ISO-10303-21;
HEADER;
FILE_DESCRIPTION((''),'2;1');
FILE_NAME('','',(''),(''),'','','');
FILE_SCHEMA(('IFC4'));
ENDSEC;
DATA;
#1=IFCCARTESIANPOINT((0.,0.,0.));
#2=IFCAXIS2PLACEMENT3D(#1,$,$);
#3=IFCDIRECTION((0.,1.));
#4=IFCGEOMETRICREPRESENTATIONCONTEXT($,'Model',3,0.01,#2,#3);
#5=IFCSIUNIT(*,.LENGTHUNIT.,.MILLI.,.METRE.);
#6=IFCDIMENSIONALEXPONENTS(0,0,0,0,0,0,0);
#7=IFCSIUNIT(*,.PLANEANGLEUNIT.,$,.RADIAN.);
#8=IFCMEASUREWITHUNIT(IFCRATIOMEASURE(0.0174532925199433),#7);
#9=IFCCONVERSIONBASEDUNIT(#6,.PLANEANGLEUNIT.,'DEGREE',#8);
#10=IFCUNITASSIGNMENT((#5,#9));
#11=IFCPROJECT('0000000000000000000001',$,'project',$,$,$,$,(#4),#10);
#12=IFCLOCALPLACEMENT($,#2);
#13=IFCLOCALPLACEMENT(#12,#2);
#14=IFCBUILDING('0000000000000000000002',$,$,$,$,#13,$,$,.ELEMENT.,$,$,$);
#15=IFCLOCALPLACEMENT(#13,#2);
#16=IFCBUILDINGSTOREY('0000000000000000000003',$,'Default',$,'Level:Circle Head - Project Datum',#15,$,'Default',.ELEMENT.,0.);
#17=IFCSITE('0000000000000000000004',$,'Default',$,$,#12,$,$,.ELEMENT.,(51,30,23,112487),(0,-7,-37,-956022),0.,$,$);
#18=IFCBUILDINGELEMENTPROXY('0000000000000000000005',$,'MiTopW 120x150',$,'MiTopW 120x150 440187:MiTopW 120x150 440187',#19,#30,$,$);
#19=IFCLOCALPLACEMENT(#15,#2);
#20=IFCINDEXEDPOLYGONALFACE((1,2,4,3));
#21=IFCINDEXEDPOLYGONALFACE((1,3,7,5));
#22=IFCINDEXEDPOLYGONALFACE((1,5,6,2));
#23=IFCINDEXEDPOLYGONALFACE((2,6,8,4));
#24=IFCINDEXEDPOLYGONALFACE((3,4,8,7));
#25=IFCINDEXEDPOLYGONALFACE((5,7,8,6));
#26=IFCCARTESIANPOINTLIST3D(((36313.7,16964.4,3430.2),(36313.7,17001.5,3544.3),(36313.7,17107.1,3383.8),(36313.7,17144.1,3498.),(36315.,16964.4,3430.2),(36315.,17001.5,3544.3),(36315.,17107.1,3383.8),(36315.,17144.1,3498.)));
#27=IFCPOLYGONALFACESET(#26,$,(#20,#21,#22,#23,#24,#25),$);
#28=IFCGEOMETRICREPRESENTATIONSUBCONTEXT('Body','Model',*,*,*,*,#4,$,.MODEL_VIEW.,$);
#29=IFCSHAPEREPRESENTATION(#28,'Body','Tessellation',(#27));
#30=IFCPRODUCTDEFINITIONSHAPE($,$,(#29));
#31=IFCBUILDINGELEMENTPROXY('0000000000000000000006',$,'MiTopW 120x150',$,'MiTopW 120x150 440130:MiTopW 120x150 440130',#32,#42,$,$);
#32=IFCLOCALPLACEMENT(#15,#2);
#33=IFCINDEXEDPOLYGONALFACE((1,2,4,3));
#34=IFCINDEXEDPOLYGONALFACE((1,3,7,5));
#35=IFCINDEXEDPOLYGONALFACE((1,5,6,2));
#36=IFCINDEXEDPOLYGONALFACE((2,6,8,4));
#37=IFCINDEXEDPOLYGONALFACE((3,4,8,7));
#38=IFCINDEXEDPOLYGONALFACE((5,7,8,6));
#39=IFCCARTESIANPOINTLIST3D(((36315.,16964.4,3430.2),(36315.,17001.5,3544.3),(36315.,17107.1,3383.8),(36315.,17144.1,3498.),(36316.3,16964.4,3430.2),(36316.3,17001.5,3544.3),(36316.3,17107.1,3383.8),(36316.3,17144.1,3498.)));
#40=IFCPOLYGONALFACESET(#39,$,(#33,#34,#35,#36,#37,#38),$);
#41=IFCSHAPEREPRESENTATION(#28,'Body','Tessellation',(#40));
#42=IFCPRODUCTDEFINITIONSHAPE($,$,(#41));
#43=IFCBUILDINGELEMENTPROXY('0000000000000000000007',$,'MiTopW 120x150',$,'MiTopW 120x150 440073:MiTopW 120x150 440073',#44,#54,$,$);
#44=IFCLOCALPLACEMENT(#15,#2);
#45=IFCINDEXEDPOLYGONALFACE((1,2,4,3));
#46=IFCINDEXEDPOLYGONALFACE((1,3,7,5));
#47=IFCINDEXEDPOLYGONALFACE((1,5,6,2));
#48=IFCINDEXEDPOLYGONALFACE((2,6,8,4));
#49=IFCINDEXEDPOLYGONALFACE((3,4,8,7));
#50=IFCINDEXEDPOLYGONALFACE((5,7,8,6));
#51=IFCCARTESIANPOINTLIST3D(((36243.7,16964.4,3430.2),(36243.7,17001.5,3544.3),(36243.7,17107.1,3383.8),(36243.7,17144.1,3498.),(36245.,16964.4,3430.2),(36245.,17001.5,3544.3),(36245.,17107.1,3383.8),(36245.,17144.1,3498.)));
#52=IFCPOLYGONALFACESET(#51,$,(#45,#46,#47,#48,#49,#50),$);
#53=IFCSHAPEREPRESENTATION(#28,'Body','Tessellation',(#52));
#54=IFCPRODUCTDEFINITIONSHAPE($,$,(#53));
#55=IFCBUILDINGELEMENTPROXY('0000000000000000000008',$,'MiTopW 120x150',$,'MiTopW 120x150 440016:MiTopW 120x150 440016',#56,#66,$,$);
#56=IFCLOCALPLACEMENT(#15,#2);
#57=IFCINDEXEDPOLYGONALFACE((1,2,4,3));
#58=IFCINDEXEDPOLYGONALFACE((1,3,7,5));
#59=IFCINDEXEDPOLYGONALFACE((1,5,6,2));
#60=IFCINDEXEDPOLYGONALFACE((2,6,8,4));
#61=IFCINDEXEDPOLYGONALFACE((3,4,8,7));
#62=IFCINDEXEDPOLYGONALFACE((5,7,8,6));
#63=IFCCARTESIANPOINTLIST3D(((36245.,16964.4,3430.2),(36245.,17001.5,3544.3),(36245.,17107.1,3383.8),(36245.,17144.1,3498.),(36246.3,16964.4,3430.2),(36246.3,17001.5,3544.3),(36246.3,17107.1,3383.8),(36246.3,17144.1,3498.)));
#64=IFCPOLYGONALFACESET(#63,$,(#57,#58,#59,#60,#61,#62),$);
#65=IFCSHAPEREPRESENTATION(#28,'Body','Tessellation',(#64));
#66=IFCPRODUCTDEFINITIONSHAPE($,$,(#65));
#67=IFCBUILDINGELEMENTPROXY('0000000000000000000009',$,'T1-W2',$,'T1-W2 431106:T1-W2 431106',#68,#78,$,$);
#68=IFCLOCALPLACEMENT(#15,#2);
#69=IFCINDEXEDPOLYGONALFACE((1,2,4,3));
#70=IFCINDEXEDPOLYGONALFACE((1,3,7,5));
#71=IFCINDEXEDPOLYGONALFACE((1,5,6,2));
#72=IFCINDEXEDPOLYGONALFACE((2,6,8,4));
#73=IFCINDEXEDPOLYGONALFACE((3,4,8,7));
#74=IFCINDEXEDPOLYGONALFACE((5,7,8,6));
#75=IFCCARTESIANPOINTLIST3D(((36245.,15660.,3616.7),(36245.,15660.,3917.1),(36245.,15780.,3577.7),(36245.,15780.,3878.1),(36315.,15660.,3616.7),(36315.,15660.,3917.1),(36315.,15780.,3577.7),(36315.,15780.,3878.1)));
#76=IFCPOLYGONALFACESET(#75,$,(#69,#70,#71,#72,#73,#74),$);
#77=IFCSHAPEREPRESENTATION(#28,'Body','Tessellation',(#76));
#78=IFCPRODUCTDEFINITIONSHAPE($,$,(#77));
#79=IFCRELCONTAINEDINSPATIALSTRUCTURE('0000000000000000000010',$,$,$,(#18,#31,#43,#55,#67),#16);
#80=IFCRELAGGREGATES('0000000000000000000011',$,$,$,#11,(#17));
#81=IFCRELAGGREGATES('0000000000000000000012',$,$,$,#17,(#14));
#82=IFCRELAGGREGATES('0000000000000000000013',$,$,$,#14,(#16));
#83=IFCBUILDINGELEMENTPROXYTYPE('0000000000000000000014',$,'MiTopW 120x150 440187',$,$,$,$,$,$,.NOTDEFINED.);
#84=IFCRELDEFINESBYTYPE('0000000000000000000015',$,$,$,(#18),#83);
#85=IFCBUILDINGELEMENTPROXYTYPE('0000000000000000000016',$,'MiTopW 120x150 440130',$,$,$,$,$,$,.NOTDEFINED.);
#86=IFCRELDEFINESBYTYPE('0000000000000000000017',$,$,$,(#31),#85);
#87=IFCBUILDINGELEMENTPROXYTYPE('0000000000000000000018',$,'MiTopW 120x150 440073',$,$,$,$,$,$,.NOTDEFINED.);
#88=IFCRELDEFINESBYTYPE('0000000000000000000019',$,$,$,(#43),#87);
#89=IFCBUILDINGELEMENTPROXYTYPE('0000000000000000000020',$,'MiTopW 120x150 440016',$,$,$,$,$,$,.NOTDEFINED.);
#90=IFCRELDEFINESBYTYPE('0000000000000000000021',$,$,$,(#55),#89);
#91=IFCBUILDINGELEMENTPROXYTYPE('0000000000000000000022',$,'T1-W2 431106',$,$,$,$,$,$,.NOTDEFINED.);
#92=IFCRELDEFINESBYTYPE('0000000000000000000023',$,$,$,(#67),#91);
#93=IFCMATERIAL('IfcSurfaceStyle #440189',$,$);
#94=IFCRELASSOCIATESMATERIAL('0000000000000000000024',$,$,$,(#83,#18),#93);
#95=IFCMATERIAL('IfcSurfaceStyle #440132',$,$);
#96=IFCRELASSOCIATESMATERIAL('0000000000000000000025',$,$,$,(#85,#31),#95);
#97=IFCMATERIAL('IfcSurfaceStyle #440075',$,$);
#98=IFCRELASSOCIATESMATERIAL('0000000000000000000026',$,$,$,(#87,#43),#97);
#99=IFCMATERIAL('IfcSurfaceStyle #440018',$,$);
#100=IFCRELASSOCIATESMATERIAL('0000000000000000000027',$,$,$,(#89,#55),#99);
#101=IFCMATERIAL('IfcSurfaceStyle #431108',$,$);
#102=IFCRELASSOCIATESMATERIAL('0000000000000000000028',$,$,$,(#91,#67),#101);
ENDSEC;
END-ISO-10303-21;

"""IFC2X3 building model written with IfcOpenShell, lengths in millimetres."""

from ifc_helpers import new_model, entity, si_unit, converted_unit, direction, frame, origin, place, context, subcontext, project, spatial, polyline, outline, extrude, source, transform, mapped, material, type_object, type_shapes, element, save


model = new_model("IFC2X3")

# Units and contexts
model_context = context("Model", 3, precision=0.01, world=origin(), true_north=direction((0.0, 1.0)))
body_context = subcontext(model_context, "Body", "Model", "MODEL_VIEW")
ifc_project = project(units=[si_unit("LENGTHUNIT", "METRE", prefix="MILLI"), converted_unit("PLANEANGLEUNIT", "DEGREE", entity("IfcRatioMeasure", 0.0174532925199433), si_unit("PLANEANGLEUNIT", "RADIAN"), dimensions=[0, 0, 0, 0, 0, 0, 0])], contexts=[model_context])

# Site, building, storey
site_placement = place(None, origin())
site = spatial("IfcSite", under=ifc_project, at=site_placement, Name="Default", CompositionType="ELEMENT", RefLatitude=(51, 30, 23, 112487), RefLongitude=(0, -7, -37, -956022), RefElevation=0.0)
building_placement = place(site_placement, origin())
building = spatial("IfcBuilding", under=site, at=building_placement, CompositionType="ELEMENT")
storey_placement = place(building_placement, origin())
storey = spatial("IfcBuildingStorey", under=building, at=storey_placement, Name="Default", ObjectType="Level:Circle Head - Project Datum", LongName="Default", CompositionType="ELEMENT", Elevation=0.0)

# Building element proxies
ifc_material_1 = material(Name="IfcSurfaceStyle #440189")
building_element_proxy_type_1 = type_object("IfcBuildingElementProxyType", Name="MiTopW 120x150 440187", PredefinedType="NOTDEFINED", material=ifc_material_1)
shared_shape_1 = source(origin(), body_context, "Body", "SweptSolid", [
    extrude(outline(polyline([(-75.0, -60.0), (75.0, -60.0), (75.0, 60.0), (-75.0, 60.0), (-75.0, -60.0)])), frame((75.0, 60.0, 0.0), z_axis=(0.0, 0.0, 1.0), x_axis=(-1.0, 0.0, 0.0)), (0.0, 0.0, 1.0), 1.3),
])
type_shapes(building_element_proxy_type_1, [shared_shape_1])
proxy_1_placement = place(building_placement, frame((36315.0, 17107.1, 3383.8), z_axis=(-1.0, 0.0, 0.0), x_axis=(0.0, -0.951057, 0.309017)))
element("IfcBuildingElementProxy", 1, at=proxy_1_placement, inside=storey, type_object=building_element_proxy_type_1, material=ifc_material_1, Name="MiTopW 120x150", ObjectType="MiTopW 120x150 440187:MiTopW 120x150 440187", context=body_context, shape_type="MappedRepresentation", body=[
    mapped(shared_shape_1, transform((0.0, 0.0, 0.0), scale=1.0)),
])
ifc_material_2 = material(Name="IfcSurfaceStyle #440132")
building_element_proxy_type_2 = type_object("IfcBuildingElementProxyType", Name="MiTopW 120x150 440130", PredefinedType="NOTDEFINED", material=ifc_material_2)
shared_shape_2 = source(origin(), body_context, "Body", "SweptSolid", [
    extrude(outline(polyline([(-75.0, -60.0), (75.0, -60.0), (75.0, 60.0), (-75.0, 60.0), (-75.0, -60.0)])), frame((75.0, 60.0, 0.0), z_axis=(0.0, 0.0, 1.0), x_axis=(-1.0, 0.0, 0.0)), (0.0, 0.0, 1.0), 1.3),
])
type_shapes(building_element_proxy_type_2, [shared_shape_2])
proxy_2_placement = place(building_placement, frame((36316.3, 17107.1, 3383.8), z_axis=(-1.0, 0.0, 0.0), x_axis=(0.0, -0.951057, 0.309017)))
element("IfcBuildingElementProxy", 2, at=proxy_2_placement, inside=storey, type_object=building_element_proxy_type_2, material=ifc_material_2, Name="MiTopW 120x150", ObjectType="MiTopW 120x150 440130:MiTopW 120x150 440130", context=body_context, shape_type="MappedRepresentation", body=[
    mapped(shared_shape_2, transform((0.0, 0.0, 0.0), scale=1.0)),
])
ifc_material_3 = material(Name="IfcSurfaceStyle #440075")
building_element_proxy_type_3 = type_object("IfcBuildingElementProxyType", Name="MiTopW 120x150 440073", PredefinedType="NOTDEFINED", material=ifc_material_3)
shared_shape_3 = source(origin(), body_context, "Body", "SweptSolid", [
    extrude(outline(polyline([(-75.0, -60.0), (75.0, -60.0), (75.0, 60.0), (-75.0, 60.0), (-75.0, -60.0)])), frame((75.0, 60.0, 0.0), z_axis=(0.0, 0.0, 1.0), x_axis=(-1.0, 0.0, 0.0)), (0.0, 0.0, 1.0), 1.3),
])
type_shapes(building_element_proxy_type_3, [shared_shape_3])
proxy_3_placement = place(building_placement, frame((36245.0, 17107.1, 3383.8), z_axis=(-1.0, 0.0, 0.0), x_axis=(0.0, -0.951057, 0.309017)))
element("IfcBuildingElementProxy", 3, at=proxy_3_placement, inside=storey, type_object=building_element_proxy_type_3, material=ifc_material_3, Name="MiTopW 120x150", ObjectType="MiTopW 120x150 440073:MiTopW 120x150 440073", context=body_context, shape_type="MappedRepresentation", body=[
    mapped(shared_shape_3, transform((0.0, 0.0, 0.0), scale=1.0)),
])
ifc_material_4 = material(Name="IfcSurfaceStyle #440018")
building_element_proxy_type_4 = type_object("IfcBuildingElementProxyType", Name="MiTopW 120x150 440016", PredefinedType="NOTDEFINED", material=ifc_material_4)
shared_shape_4 = source(origin(), body_context, "Body", "SweptSolid", [
    extrude(outline(polyline([(-75.0, -60.0), (75.0, -60.0), (75.0, 60.0), (-75.0, 60.0), (-75.0, -60.0)])), frame((75.0, 60.0, 0.0), z_axis=(0.0, 0.0, 1.0), x_axis=(-1.0, 0.0, 0.0)), (0.0, 0.0, 1.0), 1.3),
])
type_shapes(building_element_proxy_type_4, [shared_shape_4])
proxy_4_placement = place(building_placement, frame((36246.3, 17107.1, 3383.8), z_axis=(-1.0, 0.0, 0.0), x_axis=(0.0, -0.951057, 0.309017)))
element("IfcBuildingElementProxy", 4, at=proxy_4_placement, inside=storey, type_object=building_element_proxy_type_4, material=ifc_material_4, Name="MiTopW 120x150", ObjectType="MiTopW 120x150 440016:MiTopW 120x150 440016", context=body_context, shape_type="MappedRepresentation", body=[
    mapped(shared_shape_4, transform((0.0, 0.0, 0.0), scale=1.0)),
])
ifc_material_5 = material(Name="IfcSurfaceStyle #431108")
building_element_proxy_type_5 = type_object("IfcBuildingElementProxyType", Name="T1-W2 431106", PredefinedType="NOTDEFINED", material=ifc_material_5)
shared_shape_5 = source(origin(), body_context, "Body", "SweptSolid", [
    extrude(outline(polyline([(-130.7, -60.0), (169.7, -60.0), (130.7, 60.0), (-169.7, 60.0), (-130.7, -60.0)])), frame((169.7, 60.0, 0.0), z_axis=(0.0, 0.0, 1.0), x_axis=(-1.0, 0.0, 0.0)), (0.0, 0.0, 1.0), 70.0),
])
type_shapes(building_element_proxy_type_5, [shared_shape_5])
proxy_5_placement = place(building_placement, frame((36315.0, 15660.0, 3577.7), z_axis=(-1.0, 0.0, 0.0), x_axis=(0.0, 0.0, 1.0)))
element("IfcBuildingElementProxy", 5, at=proxy_5_placement, inside=storey, type_object=building_element_proxy_type_5, material=ifc_material_5, Name="T1-W2", ObjectType="T1-W2 431106:T1-W2 431106", context=body_context, shape_type="MappedRepresentation", body=[
    mapped(shared_shape_5, transform((0.0, 0.0, 0.0), scale=1.0)),
])

save(model, "model.ifc")
